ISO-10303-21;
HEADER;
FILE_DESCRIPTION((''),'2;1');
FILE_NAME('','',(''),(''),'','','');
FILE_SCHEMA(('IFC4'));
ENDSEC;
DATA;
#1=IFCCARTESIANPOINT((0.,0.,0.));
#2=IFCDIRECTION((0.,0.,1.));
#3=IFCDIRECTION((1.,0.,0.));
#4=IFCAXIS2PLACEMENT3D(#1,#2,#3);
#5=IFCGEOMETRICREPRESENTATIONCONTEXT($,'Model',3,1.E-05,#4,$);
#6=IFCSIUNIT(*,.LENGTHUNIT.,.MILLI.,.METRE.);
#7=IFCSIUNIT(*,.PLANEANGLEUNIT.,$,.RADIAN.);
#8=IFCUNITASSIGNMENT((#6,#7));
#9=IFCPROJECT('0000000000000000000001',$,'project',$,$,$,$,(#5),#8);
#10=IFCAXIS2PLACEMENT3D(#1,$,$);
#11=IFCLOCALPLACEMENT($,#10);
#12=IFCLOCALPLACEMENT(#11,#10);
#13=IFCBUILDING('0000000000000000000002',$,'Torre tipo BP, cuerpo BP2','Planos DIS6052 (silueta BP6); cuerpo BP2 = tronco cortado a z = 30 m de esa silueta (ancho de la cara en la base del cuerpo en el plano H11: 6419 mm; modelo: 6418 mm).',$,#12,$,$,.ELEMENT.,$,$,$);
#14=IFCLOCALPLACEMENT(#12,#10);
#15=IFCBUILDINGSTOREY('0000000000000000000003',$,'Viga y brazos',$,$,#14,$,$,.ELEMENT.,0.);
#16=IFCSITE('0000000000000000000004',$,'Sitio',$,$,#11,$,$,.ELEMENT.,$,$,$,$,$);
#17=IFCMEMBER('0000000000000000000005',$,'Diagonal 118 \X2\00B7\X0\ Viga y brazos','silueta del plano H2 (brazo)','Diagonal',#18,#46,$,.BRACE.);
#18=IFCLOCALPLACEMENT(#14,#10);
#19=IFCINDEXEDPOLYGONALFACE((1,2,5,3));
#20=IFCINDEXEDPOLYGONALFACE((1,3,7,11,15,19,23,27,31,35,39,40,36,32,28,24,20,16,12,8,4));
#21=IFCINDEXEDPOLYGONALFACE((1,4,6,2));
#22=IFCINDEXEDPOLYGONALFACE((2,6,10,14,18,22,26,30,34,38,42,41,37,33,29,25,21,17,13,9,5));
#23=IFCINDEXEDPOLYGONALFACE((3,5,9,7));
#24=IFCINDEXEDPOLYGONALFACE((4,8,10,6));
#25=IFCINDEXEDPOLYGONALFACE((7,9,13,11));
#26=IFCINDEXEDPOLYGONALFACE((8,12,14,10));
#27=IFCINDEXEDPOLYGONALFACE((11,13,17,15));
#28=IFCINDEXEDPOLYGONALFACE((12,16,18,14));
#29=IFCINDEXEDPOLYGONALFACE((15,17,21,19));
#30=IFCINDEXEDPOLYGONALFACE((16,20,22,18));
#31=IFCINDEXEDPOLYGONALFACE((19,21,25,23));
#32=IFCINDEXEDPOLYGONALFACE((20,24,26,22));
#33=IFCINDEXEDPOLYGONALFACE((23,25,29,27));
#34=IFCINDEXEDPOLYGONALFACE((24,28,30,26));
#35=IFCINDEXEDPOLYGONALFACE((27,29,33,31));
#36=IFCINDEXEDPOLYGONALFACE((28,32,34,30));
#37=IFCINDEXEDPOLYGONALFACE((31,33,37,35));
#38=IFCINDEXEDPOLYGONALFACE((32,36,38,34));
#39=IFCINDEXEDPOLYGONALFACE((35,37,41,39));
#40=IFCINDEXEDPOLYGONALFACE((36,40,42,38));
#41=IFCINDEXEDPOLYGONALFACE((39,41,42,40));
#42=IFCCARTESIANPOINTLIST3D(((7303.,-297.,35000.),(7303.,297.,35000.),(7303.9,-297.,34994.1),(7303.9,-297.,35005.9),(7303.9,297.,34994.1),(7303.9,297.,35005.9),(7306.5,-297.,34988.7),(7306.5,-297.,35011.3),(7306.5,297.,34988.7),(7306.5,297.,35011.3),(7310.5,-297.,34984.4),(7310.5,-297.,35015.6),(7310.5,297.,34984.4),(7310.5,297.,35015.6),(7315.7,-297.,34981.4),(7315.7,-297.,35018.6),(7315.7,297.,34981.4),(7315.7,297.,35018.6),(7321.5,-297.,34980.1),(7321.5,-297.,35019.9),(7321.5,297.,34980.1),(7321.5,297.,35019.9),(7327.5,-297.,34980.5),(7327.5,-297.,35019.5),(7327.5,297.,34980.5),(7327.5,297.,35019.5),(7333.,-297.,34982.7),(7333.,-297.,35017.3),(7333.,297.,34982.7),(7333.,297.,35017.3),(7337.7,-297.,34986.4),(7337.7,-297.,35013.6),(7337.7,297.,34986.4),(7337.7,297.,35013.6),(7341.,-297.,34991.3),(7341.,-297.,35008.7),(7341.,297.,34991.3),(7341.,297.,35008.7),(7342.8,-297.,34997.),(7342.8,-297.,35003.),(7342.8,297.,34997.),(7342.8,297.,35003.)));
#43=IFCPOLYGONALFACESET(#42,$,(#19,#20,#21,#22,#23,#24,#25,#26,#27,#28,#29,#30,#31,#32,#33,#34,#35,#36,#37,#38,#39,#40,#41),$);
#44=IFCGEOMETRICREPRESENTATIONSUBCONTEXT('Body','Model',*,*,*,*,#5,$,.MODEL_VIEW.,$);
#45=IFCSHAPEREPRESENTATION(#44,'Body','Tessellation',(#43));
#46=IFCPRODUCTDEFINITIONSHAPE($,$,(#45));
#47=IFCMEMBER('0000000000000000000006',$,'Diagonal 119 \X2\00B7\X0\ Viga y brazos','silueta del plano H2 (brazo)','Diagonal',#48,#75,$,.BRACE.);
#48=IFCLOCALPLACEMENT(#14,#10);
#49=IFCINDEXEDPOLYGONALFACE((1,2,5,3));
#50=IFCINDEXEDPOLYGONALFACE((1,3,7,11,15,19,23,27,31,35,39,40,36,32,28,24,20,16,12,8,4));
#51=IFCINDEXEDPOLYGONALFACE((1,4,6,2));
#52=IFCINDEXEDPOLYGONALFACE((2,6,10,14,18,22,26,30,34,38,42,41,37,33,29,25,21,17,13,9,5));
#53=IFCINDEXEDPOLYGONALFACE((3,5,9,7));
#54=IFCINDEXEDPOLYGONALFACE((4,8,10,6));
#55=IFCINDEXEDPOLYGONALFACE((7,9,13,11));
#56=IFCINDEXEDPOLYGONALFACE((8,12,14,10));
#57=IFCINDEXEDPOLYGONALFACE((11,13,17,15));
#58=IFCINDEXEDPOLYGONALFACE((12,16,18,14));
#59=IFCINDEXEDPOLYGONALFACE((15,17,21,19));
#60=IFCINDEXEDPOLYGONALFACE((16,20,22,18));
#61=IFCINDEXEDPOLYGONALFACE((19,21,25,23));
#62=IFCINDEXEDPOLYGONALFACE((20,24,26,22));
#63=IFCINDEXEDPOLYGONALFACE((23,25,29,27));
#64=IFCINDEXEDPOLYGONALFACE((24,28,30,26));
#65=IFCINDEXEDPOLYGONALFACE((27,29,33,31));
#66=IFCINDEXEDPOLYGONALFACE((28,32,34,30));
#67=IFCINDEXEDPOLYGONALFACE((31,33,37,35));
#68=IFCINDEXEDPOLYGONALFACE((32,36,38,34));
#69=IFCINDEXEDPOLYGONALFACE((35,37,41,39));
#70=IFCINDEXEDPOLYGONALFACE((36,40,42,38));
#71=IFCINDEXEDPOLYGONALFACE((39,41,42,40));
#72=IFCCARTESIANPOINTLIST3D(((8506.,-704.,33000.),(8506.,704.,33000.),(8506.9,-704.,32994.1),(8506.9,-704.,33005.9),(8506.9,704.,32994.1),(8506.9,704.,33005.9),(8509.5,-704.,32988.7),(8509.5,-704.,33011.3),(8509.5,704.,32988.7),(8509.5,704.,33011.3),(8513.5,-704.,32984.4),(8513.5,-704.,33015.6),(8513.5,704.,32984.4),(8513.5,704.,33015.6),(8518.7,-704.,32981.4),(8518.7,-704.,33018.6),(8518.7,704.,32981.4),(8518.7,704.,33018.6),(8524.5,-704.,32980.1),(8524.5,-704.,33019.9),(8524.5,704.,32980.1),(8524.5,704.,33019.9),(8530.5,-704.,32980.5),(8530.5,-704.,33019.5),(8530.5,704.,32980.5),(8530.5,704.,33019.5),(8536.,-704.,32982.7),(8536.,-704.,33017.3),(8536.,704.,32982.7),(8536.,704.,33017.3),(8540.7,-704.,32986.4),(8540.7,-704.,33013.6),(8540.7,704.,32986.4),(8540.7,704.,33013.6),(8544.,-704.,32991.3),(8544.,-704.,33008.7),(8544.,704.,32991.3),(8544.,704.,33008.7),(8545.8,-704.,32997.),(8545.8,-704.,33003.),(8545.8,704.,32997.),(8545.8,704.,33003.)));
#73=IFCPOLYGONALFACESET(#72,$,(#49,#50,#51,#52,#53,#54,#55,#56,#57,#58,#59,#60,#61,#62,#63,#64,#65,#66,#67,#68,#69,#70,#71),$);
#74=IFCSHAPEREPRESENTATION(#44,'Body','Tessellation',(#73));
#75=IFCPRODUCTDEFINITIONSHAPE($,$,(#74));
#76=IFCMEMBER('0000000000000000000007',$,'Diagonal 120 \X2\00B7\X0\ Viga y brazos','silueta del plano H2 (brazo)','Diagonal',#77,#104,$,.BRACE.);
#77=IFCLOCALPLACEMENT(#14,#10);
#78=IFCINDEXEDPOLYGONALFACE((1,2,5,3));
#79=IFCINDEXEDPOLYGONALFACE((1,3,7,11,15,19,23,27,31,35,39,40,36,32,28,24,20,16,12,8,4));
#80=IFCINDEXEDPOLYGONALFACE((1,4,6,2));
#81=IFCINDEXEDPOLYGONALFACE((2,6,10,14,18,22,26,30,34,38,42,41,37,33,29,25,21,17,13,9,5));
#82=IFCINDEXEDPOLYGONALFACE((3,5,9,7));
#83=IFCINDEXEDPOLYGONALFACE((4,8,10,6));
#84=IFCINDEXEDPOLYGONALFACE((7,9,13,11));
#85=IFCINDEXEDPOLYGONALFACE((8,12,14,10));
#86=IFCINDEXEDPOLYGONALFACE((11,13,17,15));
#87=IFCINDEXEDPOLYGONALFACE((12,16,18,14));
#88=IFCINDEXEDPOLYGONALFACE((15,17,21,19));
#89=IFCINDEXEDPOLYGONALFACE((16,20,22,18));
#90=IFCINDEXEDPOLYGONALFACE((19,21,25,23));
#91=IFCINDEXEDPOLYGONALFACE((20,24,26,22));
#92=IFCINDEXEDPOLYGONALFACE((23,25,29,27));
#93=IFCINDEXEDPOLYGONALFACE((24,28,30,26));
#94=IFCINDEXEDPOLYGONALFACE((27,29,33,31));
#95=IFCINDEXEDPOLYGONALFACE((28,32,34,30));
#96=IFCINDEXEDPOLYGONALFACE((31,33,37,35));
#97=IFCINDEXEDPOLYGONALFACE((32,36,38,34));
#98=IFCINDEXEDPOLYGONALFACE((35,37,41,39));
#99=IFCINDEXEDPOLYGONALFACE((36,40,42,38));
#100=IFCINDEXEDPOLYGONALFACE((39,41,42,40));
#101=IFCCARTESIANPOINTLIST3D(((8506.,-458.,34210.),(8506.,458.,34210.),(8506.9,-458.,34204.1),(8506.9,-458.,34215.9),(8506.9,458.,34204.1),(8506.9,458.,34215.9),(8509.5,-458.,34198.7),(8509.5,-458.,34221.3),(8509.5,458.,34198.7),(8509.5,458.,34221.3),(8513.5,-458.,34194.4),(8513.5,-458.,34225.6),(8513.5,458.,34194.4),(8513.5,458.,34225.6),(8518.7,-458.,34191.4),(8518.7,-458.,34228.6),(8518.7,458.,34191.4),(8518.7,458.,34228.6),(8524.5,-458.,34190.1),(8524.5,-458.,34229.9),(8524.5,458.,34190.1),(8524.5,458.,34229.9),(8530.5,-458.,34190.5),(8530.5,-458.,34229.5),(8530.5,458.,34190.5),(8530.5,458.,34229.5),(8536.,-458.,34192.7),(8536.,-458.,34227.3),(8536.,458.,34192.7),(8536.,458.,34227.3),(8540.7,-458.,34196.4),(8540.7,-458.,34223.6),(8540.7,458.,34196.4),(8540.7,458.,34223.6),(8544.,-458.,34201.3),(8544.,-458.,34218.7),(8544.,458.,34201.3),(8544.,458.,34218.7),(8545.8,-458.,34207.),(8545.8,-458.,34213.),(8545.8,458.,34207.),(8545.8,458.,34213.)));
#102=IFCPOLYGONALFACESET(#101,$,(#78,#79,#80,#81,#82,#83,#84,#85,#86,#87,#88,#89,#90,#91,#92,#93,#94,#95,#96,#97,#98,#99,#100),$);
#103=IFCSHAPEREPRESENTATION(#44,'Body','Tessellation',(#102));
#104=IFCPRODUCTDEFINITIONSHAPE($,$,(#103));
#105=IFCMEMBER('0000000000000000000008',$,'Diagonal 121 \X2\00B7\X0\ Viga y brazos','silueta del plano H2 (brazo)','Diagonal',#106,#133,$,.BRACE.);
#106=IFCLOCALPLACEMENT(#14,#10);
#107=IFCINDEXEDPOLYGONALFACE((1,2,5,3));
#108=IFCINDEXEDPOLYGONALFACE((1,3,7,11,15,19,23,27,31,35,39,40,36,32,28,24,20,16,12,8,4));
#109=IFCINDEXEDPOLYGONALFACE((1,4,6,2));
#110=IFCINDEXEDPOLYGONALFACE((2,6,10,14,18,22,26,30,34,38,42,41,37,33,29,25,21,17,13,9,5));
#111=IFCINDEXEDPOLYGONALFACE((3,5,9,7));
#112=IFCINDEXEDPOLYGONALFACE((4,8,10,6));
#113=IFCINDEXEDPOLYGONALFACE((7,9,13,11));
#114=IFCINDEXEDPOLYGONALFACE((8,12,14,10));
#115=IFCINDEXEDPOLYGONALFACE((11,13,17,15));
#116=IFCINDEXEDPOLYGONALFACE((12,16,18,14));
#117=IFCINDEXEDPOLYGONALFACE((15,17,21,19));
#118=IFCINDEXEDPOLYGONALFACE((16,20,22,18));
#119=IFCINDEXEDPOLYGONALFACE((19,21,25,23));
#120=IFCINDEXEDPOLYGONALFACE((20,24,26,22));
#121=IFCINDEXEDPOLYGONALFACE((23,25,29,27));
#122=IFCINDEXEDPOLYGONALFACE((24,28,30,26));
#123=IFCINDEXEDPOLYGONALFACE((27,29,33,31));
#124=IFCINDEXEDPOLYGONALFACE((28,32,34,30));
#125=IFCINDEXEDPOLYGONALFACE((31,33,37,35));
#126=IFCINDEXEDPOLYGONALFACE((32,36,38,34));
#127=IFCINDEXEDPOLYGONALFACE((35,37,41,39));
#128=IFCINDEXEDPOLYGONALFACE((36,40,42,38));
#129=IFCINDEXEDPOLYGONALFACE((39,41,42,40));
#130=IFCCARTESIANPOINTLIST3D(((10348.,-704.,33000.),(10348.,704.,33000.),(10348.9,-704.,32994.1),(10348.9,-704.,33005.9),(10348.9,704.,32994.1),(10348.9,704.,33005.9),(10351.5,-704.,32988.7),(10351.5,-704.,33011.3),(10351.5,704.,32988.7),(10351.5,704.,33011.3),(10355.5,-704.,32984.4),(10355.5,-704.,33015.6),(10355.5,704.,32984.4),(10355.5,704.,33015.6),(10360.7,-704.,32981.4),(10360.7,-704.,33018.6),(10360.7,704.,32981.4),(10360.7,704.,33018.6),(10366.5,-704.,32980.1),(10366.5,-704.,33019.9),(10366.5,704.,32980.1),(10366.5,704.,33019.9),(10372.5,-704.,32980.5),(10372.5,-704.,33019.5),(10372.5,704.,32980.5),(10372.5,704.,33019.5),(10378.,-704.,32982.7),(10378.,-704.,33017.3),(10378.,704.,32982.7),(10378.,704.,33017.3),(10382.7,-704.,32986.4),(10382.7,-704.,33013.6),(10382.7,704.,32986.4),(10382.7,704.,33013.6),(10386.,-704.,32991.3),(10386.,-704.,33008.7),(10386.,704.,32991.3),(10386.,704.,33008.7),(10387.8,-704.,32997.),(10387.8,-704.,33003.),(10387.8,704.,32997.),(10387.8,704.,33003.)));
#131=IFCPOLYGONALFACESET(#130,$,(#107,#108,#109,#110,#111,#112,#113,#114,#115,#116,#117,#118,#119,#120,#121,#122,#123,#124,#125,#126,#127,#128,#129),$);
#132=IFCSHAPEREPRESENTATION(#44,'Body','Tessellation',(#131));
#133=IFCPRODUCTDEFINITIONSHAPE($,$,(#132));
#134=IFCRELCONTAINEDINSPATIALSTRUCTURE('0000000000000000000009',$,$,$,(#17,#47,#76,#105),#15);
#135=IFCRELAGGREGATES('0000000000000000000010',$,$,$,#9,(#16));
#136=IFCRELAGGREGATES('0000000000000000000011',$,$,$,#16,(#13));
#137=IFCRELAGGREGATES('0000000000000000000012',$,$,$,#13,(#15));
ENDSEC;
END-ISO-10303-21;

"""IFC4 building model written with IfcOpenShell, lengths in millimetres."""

from ifc_helpers import new_model, si_unit, frame, origin, origin_with_axes, place, context, subcontext, project, spatial, circle, extrude, element, save


model = new_model("IFC4")

# Units and contexts
model_context = context("Model", 3, precision=1e-05, world=origin_with_axes())
body_context = subcontext(model_context, "Body", "Model", "MODEL_VIEW")
ifc_project = project(units=[si_unit("LENGTHUNIT", "METRE", prefix="MILLI"), si_unit("PLANEANGLEUNIT", "RADIAN")], contexts=[model_context])

# Site, building, storey
site_placement = place(None, origin())
site = spatial("IfcSite", under=ifc_project, at=site_placement, Name="Sitio", CompositionType="ELEMENT")
building_placement = place(site_placement, origin())
building = spatial("IfcBuilding", under=site, at=building_placement, Name="Torre tipo BP, cuerpo BP2", Description="Planos DIS6052 (silueta BP6); cuerpo BP2 = tronco cortado a z = 30 m de esa silueta (ancho de la cara en la base del cuerpo en el plano H11: 6419 mm; modelo: 6418 mm).", CompositionType="ELEMENT")
storey_placement = place(building_placement, origin())
storey = spatial("IfcBuildingStorey", under=building, at=storey_placement, Name="Viga y brazos", CompositionType="ELEMENT", Elevation=0.0)

# Members
member_1_placement = place(storey_placement, frame((7323.0, 297.0, 35000.0), z_axis=(0.0, -1.0, 0.0), x_axis=(-1.0, 0.0, 0.0)))
element("IfcMember", 1, at=member_1_placement, inside=storey, Name="Diagonal 118 · Viga y brazos", Description="silueta del plano H2 (brazo)", ObjectType="Diagonal", PredefinedType="BRACE", context=body_context, shape_type="SweptSolid", body=[
    extrude(circle(Radius=20.0), None, (0.0, 0.0, 1.0), 594.0),
])
member_2_placement = place(storey_placement, frame((8526.0, 704.0, 33000.0), z_axis=(0.0, -1.0, 0.0), x_axis=(-1.0, 0.0, 0.0)))
element("IfcMember", 2, at=member_2_placement, inside=storey, Name="Diagonal 119 · Viga y brazos", Description="silueta del plano H2 (brazo)", ObjectType="Diagonal", PredefinedType="BRACE", context=body_context, shape_type="SweptSolid", body=[
    extrude(circle(Radius=20.0), None, (0.0, 0.0, 1.0), 1408.0),
])
member_3_placement = place(storey_placement, frame((8526.0, 458.0, 34210.0), z_axis=(0.0, -1.0, 0.0), x_axis=(-1.0, 0.0, 0.0)))
element("IfcMember", 3, at=member_3_placement, inside=storey, Name="Diagonal 120 · Viga y brazos", Description="silueta del plano H2 (brazo)", ObjectType="Diagonal", PredefinedType="BRACE", context=body_context, shape_type="SweptSolid", body=[
    extrude(circle(Radius=20.0), None, (0.0, 0.0, 1.0), 916.0),
])
member_4_placement = place(storey_placement, frame((10368.0, 704.0, 33000.0), z_axis=(0.0, -1.0, 0.0), x_axis=(-1.0, 0.0, 0.0)))
element("IfcMember", 4, at=member_4_placement, inside=storey, Name="Diagonal 121 · Viga y brazos", Description="silueta del plano H2 (brazo)", ObjectType="Diagonal", PredefinedType="BRACE", context=body_context, shape_type="SweptSolid", body=[
    extrude(circle(Radius=20.0), None, (0.0, 0.0, 1.0), 1408.0),
])

save(model, "model.ifc")
